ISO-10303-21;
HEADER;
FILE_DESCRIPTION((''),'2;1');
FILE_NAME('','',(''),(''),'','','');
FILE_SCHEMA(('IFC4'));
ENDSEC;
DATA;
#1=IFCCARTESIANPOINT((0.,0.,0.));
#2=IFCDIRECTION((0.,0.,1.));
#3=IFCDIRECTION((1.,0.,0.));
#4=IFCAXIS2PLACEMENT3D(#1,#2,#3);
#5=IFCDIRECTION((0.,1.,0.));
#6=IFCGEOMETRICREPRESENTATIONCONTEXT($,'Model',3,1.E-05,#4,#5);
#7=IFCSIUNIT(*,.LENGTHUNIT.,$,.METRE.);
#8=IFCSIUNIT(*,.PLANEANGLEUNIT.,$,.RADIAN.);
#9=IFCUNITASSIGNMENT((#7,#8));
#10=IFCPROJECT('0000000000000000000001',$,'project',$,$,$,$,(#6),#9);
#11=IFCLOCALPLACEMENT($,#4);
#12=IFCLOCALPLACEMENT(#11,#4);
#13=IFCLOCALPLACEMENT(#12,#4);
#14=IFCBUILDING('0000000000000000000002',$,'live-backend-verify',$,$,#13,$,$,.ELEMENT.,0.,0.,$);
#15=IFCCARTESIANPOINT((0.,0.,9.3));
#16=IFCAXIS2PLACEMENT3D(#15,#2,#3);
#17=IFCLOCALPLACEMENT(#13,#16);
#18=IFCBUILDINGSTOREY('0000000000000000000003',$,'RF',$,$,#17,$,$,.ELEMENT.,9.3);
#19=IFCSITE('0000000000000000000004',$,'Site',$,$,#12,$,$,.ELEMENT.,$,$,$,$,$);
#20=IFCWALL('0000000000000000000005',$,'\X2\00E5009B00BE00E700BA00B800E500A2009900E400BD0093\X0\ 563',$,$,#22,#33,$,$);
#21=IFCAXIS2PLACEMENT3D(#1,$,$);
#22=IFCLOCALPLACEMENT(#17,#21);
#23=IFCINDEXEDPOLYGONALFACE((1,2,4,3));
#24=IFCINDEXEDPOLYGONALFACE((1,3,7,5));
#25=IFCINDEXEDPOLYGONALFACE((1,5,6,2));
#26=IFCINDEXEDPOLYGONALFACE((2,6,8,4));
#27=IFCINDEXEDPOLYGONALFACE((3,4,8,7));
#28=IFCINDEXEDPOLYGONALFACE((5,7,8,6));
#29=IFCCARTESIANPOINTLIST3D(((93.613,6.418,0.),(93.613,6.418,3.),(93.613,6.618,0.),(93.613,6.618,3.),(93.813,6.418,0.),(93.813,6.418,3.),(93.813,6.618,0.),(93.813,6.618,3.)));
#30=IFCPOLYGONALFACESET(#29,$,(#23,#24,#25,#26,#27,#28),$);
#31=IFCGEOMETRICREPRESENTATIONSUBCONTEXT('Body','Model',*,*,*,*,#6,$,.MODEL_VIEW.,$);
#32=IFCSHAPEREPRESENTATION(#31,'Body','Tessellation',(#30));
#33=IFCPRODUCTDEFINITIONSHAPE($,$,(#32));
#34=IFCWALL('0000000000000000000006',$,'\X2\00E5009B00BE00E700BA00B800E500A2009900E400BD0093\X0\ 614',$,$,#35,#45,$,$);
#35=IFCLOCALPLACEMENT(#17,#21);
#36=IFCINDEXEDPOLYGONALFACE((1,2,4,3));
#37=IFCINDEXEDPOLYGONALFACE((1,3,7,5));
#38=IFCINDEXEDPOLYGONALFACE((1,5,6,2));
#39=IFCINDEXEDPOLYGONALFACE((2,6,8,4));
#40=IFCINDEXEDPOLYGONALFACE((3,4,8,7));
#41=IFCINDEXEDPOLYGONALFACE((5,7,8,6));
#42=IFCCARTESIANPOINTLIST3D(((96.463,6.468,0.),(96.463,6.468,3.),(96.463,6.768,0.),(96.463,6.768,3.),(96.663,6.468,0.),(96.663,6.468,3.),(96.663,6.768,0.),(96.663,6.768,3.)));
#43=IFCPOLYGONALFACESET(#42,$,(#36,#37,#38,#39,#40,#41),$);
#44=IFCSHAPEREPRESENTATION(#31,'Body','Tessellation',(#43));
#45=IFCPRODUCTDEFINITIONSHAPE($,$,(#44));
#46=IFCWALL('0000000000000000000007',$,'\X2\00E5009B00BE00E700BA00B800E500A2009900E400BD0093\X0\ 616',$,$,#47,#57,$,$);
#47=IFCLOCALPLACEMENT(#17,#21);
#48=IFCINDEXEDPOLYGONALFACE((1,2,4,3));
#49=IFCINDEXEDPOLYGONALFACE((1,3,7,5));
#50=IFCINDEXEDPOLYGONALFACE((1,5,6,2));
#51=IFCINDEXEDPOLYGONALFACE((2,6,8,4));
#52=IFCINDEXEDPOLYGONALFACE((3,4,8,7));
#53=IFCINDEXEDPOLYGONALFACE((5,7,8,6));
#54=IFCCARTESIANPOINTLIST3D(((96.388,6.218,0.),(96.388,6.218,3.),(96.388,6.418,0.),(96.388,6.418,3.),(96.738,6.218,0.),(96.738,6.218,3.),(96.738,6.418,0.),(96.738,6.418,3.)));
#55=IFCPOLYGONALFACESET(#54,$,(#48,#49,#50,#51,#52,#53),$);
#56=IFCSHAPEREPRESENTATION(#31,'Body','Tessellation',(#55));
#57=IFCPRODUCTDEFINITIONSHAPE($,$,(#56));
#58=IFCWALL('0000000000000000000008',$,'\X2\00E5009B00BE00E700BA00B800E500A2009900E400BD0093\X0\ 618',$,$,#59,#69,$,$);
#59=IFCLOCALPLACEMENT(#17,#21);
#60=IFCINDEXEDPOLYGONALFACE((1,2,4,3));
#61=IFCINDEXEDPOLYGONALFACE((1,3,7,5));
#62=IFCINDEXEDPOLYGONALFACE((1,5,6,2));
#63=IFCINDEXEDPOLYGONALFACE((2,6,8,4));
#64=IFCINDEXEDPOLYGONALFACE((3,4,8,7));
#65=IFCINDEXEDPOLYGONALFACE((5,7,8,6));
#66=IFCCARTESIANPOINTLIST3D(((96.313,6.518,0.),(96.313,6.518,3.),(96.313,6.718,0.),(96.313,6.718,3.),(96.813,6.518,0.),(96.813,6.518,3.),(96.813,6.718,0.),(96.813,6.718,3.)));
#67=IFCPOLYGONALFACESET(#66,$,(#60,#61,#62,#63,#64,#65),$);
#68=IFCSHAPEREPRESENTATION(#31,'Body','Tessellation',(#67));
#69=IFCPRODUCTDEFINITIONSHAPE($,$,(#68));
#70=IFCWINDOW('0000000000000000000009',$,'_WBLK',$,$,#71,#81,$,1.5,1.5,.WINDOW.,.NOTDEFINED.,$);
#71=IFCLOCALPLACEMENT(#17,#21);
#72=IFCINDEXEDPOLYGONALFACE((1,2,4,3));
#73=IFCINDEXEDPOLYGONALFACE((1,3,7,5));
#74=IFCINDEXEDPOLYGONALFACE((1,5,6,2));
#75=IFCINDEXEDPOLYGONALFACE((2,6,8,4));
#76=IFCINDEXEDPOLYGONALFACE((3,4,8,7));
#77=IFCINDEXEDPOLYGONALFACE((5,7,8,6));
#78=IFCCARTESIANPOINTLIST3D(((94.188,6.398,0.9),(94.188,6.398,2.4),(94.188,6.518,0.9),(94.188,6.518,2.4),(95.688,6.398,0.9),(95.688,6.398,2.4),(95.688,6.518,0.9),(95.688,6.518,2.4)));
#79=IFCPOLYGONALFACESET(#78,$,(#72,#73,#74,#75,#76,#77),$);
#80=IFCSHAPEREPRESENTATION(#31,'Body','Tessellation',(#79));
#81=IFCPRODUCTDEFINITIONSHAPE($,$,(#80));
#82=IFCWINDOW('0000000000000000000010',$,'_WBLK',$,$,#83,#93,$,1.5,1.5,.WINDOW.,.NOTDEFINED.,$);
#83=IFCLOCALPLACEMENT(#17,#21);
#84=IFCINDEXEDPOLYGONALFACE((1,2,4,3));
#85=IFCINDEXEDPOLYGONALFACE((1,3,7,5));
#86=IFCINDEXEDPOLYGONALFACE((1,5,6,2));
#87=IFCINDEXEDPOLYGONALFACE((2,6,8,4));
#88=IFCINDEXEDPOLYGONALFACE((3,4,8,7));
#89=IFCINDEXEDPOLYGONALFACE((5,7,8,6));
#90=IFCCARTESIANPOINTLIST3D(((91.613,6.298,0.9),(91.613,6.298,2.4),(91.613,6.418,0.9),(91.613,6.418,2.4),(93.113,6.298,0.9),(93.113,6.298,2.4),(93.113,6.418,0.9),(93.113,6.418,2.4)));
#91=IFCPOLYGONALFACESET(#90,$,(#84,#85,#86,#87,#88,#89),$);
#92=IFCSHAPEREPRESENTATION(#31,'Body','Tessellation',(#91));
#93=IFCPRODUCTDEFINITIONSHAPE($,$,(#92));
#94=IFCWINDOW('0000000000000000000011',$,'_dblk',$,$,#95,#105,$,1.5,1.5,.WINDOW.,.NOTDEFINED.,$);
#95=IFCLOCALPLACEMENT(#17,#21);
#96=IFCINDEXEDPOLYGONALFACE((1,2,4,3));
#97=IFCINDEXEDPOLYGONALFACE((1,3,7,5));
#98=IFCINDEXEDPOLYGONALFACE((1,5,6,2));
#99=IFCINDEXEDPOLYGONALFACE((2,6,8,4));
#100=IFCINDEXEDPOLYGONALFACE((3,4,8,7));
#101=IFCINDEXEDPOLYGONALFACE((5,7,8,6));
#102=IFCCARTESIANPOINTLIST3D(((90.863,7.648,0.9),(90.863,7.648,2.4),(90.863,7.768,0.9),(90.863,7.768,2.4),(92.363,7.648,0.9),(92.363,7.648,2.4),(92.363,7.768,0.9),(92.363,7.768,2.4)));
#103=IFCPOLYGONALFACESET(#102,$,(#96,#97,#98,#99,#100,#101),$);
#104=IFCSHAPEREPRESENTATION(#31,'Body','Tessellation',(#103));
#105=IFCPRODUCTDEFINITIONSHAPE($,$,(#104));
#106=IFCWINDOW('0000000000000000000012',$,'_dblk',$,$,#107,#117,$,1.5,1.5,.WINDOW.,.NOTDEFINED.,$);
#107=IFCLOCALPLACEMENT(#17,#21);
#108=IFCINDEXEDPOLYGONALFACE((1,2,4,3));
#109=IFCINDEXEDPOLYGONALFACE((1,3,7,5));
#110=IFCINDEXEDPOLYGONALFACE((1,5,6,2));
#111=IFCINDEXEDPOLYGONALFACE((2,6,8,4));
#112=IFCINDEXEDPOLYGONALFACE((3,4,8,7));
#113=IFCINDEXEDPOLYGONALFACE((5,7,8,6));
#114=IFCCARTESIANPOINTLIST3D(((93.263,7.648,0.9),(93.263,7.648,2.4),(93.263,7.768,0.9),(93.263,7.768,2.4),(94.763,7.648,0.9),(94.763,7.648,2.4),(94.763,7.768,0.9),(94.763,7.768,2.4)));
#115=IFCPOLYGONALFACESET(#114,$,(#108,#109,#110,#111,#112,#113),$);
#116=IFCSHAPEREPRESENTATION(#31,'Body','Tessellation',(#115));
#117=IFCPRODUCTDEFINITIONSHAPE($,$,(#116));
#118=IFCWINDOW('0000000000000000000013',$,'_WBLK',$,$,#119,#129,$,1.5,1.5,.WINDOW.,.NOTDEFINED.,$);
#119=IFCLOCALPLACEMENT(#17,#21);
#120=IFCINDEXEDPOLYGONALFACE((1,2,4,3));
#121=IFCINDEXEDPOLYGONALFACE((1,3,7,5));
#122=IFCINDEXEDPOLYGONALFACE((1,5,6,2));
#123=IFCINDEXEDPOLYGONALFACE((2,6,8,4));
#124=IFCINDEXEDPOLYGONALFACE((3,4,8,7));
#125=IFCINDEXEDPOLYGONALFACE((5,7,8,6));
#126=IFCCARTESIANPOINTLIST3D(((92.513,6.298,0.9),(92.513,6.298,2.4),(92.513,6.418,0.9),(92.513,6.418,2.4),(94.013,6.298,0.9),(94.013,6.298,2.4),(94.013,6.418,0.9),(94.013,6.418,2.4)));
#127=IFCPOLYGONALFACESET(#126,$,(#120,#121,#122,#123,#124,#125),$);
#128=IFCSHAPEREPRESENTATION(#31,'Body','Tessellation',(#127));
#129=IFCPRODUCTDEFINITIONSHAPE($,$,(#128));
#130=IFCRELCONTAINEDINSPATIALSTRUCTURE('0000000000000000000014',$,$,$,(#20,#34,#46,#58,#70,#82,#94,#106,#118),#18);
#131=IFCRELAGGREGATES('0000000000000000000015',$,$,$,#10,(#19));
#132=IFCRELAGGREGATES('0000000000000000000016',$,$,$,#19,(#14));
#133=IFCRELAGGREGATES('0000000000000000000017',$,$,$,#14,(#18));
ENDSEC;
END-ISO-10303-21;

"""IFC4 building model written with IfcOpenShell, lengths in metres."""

from ifc_helpers import new_model, si_unit, direction, frame, frame_2d, origin_with_axes, place, context, subcontext, project, spatial, rectangle, extrude, element, save


model = new_model("IFC4")

# Units and contexts
model_context = context("Model", 3, precision=1e-05, world=origin_with_axes(), true_north=direction((0.0, 1.0, 0.0)))
body_context = subcontext(model_context, "Body", "Model", "MODEL_VIEW")
ifc_project = project(units=[si_unit("LENGTHUNIT", "METRE"), si_unit("PLANEANGLEUNIT", "RADIAN")], contexts=[model_context])

# Site, building, storey
placement = place(None, origin_with_axes())
site_placement = place(placement, origin_with_axes())
site = spatial("IfcSite", under=ifc_project, at=site_placement, Name="Site", CompositionType="ELEMENT")
building_placement = place(site_placement, origin_with_axes())
building = spatial("IfcBuilding", under=site, at=building_placement, Name="live-backend-verify", CompositionType="ELEMENT", ElevationOfRefHeight=0.0, ElevationOfTerrain=0.0)
storey_placement = place(building_placement, frame((0.0, 0.0, 9.3), z_axis=(0.0, 0.0, 1.0), x_axis=(1.0, 0.0, 0.0)))
storey = spatial("IfcBuildingStorey", under=building, at=storey_placement, Name="RF", CompositionType="ELEMENT", Elevation=9.3)

# Walls
for number, where, z_axis, x_axis, name in (
    (1, (93.713, 6.518, 0.0), (0.0, 0.0, 1.0), (0.0, -1.0, 0.0), "å\u009b¾çº¸å¢\u0099ä½\u0093 563"),
):
    element("IfcWall", number, at=place(storey_placement, frame(where, z_axis=z_axis, x_axis=x_axis)), inside=storey, Name=name, context=body_context, shape_type="SweptSolid", body=[
        extrude(rectangle(XDim=0.2, YDim=0.2, at=frame_2d((0.0, 0.0), x_axis=(1.0, 0.0, 0.0))), frame((0.0, 0.0, 0.0), z_axis=(0.0, 0.0, 1.0)), (0.0, 0.0, 1.0), 3.0),
    ])
wall_1_placement = place(storey_placement, frame((96.563, 6.618, 0.0), z_axis=(0.0, 0.0, 1.0), x_axis=(0.0, -1.0, 0.0)))
element("IfcWall", 2, at=wall_1_placement, inside=storey, Name="å\u009b¾çº¸å¢\u0099ä½\u0093 614", context=body_context, shape_type="SweptSolid", body=[
    extrude(rectangle(XDim=0.3, YDim=0.2, at=frame_2d((0.0, 0.0), x_axis=(1.0, 0.0, 0.0))), frame((0.0, 0.0, 0.0), z_axis=(0.0, 0.0, 1.0)), (0.0, 0.0, 1.0), 3.0),
])
wall_2_placement = place(storey_placement, frame((96.563, 6.318, 0.0), z_axis=(0.0, 0.0, 1.0), x_axis=(1.0, 0.0, 0.0)))
element("IfcWall", 3, at=wall_2_placement, inside=storey, Name="å\u009b¾çº¸å¢\u0099ä½\u0093 616", context=body_context, shape_type="SweptSolid", body=[
    extrude(rectangle(XDim=0.35, YDim=0.2, at=frame_2d((0.0, 0.0), x_axis=(1.0, 0.0, 0.0))), frame((0.0, 0.0, 0.0), z_axis=(0.0, 0.0, 1.0)), (0.0, 0.0, 1.0), 3.0),
])
for number, where, z_axis, x_axis, name in (
    (4, (96.563, 6.618, 0.0), (0.0, 0.0, 1.0), (1.0, 0.0, 0.0), "å\u009b¾çº¸å¢\u0099ä½\u0093 618"),
):
    element("IfcWall", number, at=place(storey_placement, frame(where, z_axis=z_axis, x_axis=x_axis)), inside=storey, Name=name, context=body_context, shape_type="SweptSolid", body=[
        extrude(rectangle(XDim=0.5, YDim=0.2, at=frame_2d((0.0, 0.0), x_axis=(1.0, 0.0, 0.0))), frame((0.0, 0.0, 0.0), z_axis=(0.0, 0.0, 1.0)), (0.0, 0.0, 1.0), 3.0),
    ])

# Windows
for number, where, z_axis, x_axis, name in (
    (5, (94.938, 6.458, 0.9), (0.0, 0.0, 1.0), (1.0, 0.0, 0.0), "_WBLK"),
    (6, (92.363, 6.358, 0.9), (0.0, 0.0, 1.0), (1.0, 0.0, 0.0), "_WBLK"),
    (7, (91.613, 7.708, 0.9), (0.0, 0.0, 1.0), (1.0, 0.0, 0.0), "_dblk"),
    (8, (94.013, 7.708, 0.9), (0.0, 0.0, 1.0), (1.0, 0.0, 0.0), "_dblk"),
    (9, (93.263, 6.358, 0.9), (0.0, 0.0, 1.0), (1.0, 0.0, 0.0), "_WBLK"),
):
    element("IfcWindow", number, at=place(storey_placement, frame(where, z_axis=z_axis, x_axis=x_axis)), inside=storey, Name=name, OverallHeight=1.5, OverallWidth=1.5, PartitioningType="NOTDEFINED", PredefinedType="WINDOW", context=body_context, shape_type="SweptSolid", body=[
        extrude(rectangle(XDim=1.5, YDim=0.12, at=frame_2d((0.0, 0.0), x_axis=(1.0, 0.0, 0.0))), frame((0.0, 0.0, 0.0), z_axis=(0.0, 0.0, 1.0)), (0.0, 0.0, 1.0), 1.5),
    ])

save(model, "model.ifc")
